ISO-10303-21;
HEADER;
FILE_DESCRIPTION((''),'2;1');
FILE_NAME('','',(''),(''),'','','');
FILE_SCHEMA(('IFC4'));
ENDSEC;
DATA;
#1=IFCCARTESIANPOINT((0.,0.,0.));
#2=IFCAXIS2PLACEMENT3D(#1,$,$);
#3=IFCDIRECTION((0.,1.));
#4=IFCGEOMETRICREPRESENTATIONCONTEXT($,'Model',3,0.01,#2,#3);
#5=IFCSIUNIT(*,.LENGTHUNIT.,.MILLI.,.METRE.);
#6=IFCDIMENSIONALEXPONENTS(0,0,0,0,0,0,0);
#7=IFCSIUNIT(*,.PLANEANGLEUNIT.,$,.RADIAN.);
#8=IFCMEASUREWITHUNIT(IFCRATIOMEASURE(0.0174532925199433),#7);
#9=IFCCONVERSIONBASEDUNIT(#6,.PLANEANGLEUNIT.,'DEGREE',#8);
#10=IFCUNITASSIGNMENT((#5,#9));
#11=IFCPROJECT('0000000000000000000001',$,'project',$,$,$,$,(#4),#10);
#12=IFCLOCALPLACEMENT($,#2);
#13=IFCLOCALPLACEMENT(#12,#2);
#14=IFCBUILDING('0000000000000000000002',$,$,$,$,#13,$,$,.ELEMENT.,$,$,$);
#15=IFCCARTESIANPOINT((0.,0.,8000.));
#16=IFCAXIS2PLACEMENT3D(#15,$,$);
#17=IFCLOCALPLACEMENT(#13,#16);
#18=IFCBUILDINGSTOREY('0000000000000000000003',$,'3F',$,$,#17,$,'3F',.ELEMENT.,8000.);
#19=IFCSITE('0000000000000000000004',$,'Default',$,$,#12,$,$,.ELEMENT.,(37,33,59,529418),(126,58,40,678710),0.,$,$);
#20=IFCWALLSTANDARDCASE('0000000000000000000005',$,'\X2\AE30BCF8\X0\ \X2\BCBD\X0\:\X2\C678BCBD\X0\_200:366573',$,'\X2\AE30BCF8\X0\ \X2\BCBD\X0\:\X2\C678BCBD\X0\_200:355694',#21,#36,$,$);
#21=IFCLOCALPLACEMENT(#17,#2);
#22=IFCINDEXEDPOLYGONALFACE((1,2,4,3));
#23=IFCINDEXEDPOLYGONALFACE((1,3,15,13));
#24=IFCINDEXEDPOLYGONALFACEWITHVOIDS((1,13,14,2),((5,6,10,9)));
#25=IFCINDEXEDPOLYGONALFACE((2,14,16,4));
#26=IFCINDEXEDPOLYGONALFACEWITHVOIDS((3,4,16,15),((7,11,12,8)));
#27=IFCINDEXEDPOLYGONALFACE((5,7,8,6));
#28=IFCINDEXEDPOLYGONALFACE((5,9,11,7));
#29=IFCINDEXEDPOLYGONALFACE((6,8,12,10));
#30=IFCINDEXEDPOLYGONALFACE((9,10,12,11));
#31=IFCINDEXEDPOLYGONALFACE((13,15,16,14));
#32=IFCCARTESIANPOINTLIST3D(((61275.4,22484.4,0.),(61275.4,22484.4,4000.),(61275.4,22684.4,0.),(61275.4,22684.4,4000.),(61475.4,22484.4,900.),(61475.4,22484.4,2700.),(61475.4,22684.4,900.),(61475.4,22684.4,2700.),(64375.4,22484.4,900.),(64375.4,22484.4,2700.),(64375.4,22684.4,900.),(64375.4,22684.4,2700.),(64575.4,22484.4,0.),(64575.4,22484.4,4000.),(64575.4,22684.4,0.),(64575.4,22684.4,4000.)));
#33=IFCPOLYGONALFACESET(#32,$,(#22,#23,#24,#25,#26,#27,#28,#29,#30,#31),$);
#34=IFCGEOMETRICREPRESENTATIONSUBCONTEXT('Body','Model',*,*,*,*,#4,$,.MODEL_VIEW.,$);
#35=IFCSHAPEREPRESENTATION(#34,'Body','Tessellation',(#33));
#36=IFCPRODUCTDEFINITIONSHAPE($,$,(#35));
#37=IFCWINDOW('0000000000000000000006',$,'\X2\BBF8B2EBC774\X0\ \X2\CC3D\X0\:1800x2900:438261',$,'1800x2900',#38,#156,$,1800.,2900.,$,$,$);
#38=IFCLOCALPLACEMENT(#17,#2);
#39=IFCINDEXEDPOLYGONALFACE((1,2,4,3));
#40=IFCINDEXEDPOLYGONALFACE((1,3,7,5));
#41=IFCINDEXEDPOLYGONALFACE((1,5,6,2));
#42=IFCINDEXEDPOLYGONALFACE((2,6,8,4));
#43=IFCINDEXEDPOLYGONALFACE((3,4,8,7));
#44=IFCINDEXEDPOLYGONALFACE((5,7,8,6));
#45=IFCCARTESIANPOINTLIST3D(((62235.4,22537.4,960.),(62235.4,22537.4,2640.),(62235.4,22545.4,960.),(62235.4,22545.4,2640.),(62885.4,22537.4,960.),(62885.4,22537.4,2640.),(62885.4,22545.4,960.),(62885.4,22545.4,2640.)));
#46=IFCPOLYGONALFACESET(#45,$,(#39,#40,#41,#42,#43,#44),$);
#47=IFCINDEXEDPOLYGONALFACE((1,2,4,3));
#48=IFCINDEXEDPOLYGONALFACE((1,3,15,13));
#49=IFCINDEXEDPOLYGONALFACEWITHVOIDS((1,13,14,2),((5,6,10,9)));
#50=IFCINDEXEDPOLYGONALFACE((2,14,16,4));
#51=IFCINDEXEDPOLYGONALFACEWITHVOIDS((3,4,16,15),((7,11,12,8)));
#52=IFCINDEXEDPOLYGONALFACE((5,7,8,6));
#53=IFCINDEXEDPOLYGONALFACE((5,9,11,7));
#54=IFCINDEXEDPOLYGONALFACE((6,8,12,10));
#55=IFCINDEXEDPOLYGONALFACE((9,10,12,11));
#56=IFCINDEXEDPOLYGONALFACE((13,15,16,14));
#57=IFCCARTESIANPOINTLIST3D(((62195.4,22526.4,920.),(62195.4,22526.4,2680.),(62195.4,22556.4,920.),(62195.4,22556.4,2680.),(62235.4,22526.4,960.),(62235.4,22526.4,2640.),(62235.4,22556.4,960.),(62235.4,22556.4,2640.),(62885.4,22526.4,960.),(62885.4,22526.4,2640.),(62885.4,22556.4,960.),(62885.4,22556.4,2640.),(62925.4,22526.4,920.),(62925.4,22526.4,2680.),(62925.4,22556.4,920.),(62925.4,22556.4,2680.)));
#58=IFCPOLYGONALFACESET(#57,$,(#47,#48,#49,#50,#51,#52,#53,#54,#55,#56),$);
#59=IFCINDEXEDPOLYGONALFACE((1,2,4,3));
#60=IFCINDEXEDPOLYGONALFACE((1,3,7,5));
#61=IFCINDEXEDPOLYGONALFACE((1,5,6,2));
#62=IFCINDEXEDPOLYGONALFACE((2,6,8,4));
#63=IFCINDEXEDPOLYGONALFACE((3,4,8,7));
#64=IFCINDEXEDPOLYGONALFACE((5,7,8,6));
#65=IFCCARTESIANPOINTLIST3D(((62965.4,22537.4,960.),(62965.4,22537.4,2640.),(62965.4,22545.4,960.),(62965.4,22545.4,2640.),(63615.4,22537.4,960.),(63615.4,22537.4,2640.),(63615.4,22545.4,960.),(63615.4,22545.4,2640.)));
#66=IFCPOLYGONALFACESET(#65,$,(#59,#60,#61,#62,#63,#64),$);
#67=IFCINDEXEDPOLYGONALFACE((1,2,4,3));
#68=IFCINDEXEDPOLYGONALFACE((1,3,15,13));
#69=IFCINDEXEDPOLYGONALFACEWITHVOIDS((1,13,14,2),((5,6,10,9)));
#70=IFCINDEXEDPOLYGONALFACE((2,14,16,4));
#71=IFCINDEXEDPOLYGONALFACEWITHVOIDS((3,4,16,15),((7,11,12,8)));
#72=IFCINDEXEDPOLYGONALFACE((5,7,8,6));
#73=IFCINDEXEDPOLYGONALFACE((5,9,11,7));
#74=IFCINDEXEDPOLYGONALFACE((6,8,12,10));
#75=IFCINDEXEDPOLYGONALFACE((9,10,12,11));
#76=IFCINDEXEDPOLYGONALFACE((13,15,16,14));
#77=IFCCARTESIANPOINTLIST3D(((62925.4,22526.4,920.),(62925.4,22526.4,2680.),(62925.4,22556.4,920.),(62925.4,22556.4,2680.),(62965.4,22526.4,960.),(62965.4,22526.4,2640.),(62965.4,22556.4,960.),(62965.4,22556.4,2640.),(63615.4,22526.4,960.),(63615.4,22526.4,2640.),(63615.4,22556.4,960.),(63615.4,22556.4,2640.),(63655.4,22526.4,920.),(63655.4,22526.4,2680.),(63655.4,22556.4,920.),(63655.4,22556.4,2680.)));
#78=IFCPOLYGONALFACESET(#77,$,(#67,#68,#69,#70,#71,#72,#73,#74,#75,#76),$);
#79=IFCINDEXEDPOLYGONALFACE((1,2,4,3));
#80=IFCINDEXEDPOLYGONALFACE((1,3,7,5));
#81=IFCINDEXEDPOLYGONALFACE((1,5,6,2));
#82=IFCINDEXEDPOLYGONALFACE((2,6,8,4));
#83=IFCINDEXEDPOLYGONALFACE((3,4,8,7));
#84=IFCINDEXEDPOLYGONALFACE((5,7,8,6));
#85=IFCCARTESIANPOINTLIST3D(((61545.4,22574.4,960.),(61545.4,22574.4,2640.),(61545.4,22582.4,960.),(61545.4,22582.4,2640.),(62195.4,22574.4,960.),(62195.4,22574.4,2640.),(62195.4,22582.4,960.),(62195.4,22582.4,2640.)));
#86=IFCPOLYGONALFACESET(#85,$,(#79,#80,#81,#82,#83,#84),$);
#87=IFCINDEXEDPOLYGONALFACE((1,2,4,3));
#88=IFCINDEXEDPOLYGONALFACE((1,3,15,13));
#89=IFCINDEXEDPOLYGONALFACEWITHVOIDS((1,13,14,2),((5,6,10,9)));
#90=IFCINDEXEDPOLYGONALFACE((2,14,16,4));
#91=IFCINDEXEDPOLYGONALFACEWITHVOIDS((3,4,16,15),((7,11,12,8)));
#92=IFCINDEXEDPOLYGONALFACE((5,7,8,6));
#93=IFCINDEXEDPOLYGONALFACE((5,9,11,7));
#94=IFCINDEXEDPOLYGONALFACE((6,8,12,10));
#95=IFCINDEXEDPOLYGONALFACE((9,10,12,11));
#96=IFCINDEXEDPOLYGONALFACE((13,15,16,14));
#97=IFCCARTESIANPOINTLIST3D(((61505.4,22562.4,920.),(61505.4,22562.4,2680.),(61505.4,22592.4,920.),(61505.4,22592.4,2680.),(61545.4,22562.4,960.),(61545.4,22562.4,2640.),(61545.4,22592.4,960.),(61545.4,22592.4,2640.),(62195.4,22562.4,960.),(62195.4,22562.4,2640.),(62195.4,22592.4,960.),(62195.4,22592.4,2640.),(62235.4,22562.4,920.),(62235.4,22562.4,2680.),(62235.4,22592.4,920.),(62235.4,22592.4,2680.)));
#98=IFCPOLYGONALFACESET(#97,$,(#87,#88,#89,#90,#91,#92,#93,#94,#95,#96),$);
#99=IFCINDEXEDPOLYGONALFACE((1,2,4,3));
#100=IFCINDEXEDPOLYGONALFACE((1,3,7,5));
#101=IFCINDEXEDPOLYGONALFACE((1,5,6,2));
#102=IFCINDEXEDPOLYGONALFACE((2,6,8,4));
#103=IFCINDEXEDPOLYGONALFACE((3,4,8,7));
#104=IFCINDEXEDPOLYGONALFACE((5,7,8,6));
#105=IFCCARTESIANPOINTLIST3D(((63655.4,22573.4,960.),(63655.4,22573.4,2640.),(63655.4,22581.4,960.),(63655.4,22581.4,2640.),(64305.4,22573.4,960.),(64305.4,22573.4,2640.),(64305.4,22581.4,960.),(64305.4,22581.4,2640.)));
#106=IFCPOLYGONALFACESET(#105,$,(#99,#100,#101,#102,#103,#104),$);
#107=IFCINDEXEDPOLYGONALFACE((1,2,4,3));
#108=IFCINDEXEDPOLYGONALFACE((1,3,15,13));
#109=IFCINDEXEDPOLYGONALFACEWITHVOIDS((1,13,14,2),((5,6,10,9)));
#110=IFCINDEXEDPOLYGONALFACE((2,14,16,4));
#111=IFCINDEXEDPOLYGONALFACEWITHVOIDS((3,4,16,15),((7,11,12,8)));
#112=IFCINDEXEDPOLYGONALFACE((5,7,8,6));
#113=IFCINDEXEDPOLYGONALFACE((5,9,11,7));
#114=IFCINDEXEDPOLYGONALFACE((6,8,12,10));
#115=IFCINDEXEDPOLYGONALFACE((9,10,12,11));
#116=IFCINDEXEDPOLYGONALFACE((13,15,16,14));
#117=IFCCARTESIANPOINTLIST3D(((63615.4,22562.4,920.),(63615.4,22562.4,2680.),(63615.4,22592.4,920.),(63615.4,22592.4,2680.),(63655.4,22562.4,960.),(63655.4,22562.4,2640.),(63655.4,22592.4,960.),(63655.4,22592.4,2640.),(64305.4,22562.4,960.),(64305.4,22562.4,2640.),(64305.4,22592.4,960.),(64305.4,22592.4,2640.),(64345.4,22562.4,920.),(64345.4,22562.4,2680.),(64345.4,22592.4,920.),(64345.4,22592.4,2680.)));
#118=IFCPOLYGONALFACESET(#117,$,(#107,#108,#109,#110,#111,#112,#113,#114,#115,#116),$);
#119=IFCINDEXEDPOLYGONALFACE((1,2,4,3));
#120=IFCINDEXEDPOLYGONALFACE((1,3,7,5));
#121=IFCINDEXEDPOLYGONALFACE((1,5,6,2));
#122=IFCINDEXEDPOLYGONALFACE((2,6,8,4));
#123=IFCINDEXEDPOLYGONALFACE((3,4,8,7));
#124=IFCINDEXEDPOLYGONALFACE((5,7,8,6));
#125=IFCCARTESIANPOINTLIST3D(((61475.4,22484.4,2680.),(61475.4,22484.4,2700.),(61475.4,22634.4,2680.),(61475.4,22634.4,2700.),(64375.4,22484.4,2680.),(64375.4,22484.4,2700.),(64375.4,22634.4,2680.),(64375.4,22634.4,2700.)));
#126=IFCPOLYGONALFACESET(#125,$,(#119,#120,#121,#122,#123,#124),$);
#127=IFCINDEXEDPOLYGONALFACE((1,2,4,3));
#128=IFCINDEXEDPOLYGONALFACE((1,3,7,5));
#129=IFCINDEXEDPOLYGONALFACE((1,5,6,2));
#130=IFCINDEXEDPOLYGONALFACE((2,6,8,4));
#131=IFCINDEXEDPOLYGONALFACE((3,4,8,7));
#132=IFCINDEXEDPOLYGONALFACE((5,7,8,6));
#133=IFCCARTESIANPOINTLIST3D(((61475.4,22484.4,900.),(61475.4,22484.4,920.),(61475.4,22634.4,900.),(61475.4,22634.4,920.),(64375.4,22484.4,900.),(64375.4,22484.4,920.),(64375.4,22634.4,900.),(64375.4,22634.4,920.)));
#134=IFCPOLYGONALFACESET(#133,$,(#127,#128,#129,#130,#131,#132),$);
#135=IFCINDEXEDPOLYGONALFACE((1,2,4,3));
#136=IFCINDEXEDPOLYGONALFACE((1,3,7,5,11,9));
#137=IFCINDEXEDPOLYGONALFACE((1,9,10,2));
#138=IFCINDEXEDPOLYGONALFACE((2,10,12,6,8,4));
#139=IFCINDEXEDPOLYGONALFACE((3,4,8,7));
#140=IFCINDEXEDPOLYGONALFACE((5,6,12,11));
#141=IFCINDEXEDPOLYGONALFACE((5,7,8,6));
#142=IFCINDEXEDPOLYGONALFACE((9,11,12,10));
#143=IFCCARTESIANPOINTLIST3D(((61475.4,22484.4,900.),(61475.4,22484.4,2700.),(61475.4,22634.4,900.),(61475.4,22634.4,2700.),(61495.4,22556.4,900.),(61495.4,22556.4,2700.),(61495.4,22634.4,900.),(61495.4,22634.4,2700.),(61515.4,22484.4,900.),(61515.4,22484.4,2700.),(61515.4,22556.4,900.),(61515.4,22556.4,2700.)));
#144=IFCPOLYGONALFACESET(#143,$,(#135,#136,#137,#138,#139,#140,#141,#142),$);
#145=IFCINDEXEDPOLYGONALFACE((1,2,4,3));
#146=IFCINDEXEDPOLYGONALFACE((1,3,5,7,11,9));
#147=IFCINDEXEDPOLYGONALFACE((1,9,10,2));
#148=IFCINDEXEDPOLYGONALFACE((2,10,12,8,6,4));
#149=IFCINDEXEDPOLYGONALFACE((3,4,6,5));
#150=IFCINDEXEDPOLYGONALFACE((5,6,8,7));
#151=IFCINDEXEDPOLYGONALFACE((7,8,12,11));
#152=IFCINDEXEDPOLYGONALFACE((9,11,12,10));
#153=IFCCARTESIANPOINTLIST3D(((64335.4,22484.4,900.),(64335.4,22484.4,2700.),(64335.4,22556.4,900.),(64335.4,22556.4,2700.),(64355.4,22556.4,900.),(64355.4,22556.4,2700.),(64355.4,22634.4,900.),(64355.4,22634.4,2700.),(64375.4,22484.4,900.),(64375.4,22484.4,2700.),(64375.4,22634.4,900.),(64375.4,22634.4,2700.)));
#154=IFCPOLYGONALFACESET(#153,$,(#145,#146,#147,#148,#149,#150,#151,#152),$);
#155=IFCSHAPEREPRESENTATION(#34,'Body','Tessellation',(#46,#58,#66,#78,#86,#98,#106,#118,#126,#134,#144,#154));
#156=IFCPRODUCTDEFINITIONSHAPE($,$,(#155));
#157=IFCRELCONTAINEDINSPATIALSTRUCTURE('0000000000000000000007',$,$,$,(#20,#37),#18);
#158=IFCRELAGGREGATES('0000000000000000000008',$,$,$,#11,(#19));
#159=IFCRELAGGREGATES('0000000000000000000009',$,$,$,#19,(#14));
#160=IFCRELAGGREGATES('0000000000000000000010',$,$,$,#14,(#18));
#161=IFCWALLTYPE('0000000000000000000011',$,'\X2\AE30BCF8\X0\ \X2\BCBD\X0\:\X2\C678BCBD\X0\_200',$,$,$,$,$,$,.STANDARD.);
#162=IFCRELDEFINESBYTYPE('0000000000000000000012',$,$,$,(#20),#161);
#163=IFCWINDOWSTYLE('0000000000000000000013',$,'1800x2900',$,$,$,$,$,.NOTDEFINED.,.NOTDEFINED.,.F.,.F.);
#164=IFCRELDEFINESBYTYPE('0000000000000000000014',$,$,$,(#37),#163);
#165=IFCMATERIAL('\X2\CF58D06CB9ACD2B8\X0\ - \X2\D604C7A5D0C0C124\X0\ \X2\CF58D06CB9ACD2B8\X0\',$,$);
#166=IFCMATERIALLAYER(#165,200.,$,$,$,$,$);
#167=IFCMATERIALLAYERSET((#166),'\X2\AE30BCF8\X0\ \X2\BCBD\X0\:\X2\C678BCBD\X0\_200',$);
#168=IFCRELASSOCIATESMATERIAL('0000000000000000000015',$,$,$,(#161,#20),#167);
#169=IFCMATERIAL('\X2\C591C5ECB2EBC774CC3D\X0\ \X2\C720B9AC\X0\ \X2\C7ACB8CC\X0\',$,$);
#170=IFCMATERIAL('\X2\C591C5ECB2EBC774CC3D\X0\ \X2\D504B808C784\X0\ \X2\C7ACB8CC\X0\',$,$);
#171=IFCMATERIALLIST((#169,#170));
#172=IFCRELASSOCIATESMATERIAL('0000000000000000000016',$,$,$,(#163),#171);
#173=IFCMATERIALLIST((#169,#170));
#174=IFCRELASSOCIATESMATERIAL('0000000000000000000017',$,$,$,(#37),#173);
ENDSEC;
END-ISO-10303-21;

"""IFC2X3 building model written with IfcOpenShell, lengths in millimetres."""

from ifc_helpers import new_model, entity, si_unit, converted_unit, direction, frame, frame_2d, origin, origin_2d_with_axis, place, context, subcontext, project, spatial, polyline, rectangle, outline, extrude, source, transform, mapped, material, material_list, layer, layer_set, layer_usage, type_object, type_shapes, element, fill, save


model = new_model("IFC2X3")

# Units and contexts
model_context = context("Model", 3, precision=0.01, world=origin(), true_north=direction((0.0, 1.0)))
body_context = subcontext(model_context, "Body", "Model", "MODEL_VIEW")
ifc_project = project(units=[si_unit("LENGTHUNIT", "METRE", prefix="MILLI"), converted_unit("PLANEANGLEUNIT", "DEGREE", entity("IfcRatioMeasure", 0.0174532925199433), si_unit("PLANEANGLEUNIT", "RADIAN"), dimensions=[0, 0, 0, 0, 0, 0, 0])], contexts=[model_context])

# Site, building, storey
site_placement = place(None, origin())
site = spatial("IfcSite", under=ifc_project, at=site_placement, Name="Default", CompositionType="ELEMENT", RefLatitude=(37, 33, 59, 529418), RefLongitude=(126, 58, 40, 678710), RefElevation=0.0)
building_placement = place(site_placement, origin())
building = spatial("IfcBuilding", under=site, at=building_placement, CompositionType="ELEMENT")
storey_placement = place(building_placement, frame((0.0, 0.0, 8000.0)))
storey = spatial("IfcBuildingStorey", under=building, at=storey_placement, Name="3F", LongName="3F", CompositionType="ELEMENT", Elevation=8000.0)

# Wall, opening, window
ifc_material_1 = material(Name="콘크리트 - 현장타설 콘크리트")
ifc_layer_1 = layer(ifc_material_1, 200.0)
ifc_layer_set_1 = layer_set([ifc_layer_1], Name="기본 벽:외벽_200")
wall_type_1 = type_object("IfcWallType", Name="기본 벽:외벽_200", PredefinedType="STANDARD", material=ifc_layer_set_1)
ifc_material_2 = material(Name="양여닫이창 유리 재료")
ifc_material_3 = material(Name="양여닫이창 프레임 재료")
ifc_material_list_1 = material_list([ifc_material_2, ifc_material_3])
window_style = type_object("IfcWindowStyle", Name="1800x2900", ConstructionType="NOTDEFINED", OperationType="NOTDEFINED", ParameterTakesPrecedence=False, Sizeable=False, material=ifc_material_list_1)
shared_shape_1 = source(origin(), body_context, "Body", "SweptSolid", [
    extrude(rectangle(XDim=8.0, YDim=650.0, at=frame_2d((0.0, 0.0), x_axis=(1.0, 0.0))), frame((1815.0, 143.0, 60.0), z_axis=(0.0, 0.0, 1.0), x_axis=(0.0, 1.0, 0.0)), (0.0, 0.0, 1.0), 1680.0),
    extrude(outline(polyline([(-880.0, -365.0), (880.0, -365.0), (880.0, 365.0), (-880.0, 365.0), (-880.0, -365.0)]), holes=[polyline([(840.0, -325.0), (-840.0, -325.0), (-840.0, 325.0), (840.0, 325.0), (840.0, -325.0)])]), frame((1815.0, 128.0, 900.0), z_axis=(0.0, 1.0, 0.0), x_axis=(0.0, 0.0, -1.0)), (0.0, 0.0, 1.0), 30.0),
    extrude(rectangle(XDim=8.0, YDim=650.0, at=frame_2d((0.0, 0.0), x_axis=(1.0, 0.0))), frame((1085.0, 143.0, 60.0), z_axis=(0.0, 0.0, 1.0), x_axis=(0.0, 1.0, 0.0)), (0.0, 0.0, 1.0), 1680.0),
    extrude(outline(polyline([(-880.0, -365.0), (880.0, -365.0), (880.0, 365.0), (-880.0, 365.0), (-880.0, -365.0)]), holes=[polyline([(840.0, -325.0), (-840.0, -325.0), (-840.0, 325.0), (840.0, 325.0), (840.0, -325.0)])]), frame((1085.0, 128.0, 900.0), z_axis=(0.0, 1.0, 0.0), x_axis=(0.0, 0.0, -1.0)), (0.0, 0.0, 1.0), 30.0),
    extrude(rectangle(XDim=8.0, YDim=650.0, at=frame_2d((0.0, 0.0), x_axis=(1.0, 0.0))), frame((2505.0, 106.0, 60.0), z_axis=(0.0, 0.0, 1.0), x_axis=(0.0, 1.0, 0.0)), (0.0, 0.0, 1.0), 1680.0),
    extrude(outline(polyline([(-880.0, -365.0), (880.0, -365.0), (880.0, 365.0), (-880.0, 365.0), (-880.0, -365.0)]), holes=[polyline([(840.0, -325.0), (-840.0, -325.0), (-840.0, 325.0), (840.0, 325.0), (840.0, -325.0)])]), frame((2505.0, 92.0, 900.0), z_axis=(0.0, 1.0, 0.0), x_axis=(0.0, 0.0, -1.0)), (0.0, 0.0, 1.0), 30.0),
    extrude(rectangle(XDim=8.0, YDim=650.0, at=origin_2d_with_axis()), frame((395.0, 107.0, 60.0), z_axis=(0.0, 0.0, 1.0), x_axis=(0.0, 1.0, 0.0)), (0.0, 0.0, 1.0), 1680.0),
    extrude(outline(polyline([(-880.0, -365.0), (880.0, -365.0), (880.0, 365.0), (-880.0, 365.0), (-880.0, -365.0)]), holes=[polyline([(840.0, -325.0), (-840.0, -325.0), (-840.0, 325.0), (840.0, 325.0), (840.0, -325.0)])]), frame((395.0, 92.0, 900.0), z_axis=(0.0, 1.0, 0.0), x_axis=(0.0, 0.0, -1.0)), (0.0, 0.0, 1.0), 30.0),
    extrude(rectangle(XDim=2900.0, YDim=150.0, at=origin_2d_with_axis()), frame((1450.0, 125.0, 1780.0), z_axis=(0.0, 0.0, 1.0), x_axis=(-1.0, 0.0, 0.0)), (0.0, 0.0, 1.0), 20.0),
    extrude(rectangle(XDim=2900.0, YDim=150.0, at=origin_2d_with_axis()), frame((1450.0, 125.0, 0.0), z_axis=(0.0, 0.0, 1.0), x_axis=(-1.0, 0.0, 0.0)), (0.0, 0.0, 1.0), 20.0),
    extrude(outline(polyline([(-74.0, -20.0), (-2.0, -20.0), (-2.0, 0.0), (76.0, 0.0), (76.0, 20.0), (-74.0, 20.0), (-74.0, -20.0)])), frame((2880.0, 126.0, 0.0), z_axis=(0.0, 0.0, 1.0), x_axis=(0.0, -1.0, 0.0)), (0.0, 0.0, 1.0), 1800.0),
    extrude(outline(polyline([(-20.0, -74.0), (20.0, -74.0), (20.0, 76.0), (0.0, 76.0), (0.0, -2.0), (-20.0, -2.0), (-20.0, -74.0)])), frame((20.0, 126.0, 0.0), z_axis=(0.0, 0.0, 1.0), x_axis=(-1.0, 0.0, 0.0)), (0.0, 0.0, 1.0), 1800.0),
])
type_shapes(window_style, [shared_shape_1])
ifc_layer_usage_1 = layer_usage(ifc_layer_set_1, "AXIS2", "NEGATIVE", 100.0)
wall_1_placement = place(storey_placement, frame((64575.4, 22584.4, 0.0), z_axis=(0.0, 0.0, 1.0), x_axis=(-1.0, 0.0, 0.0)))
wall_1 = element("IfcWallStandardCase", 1, at=wall_1_placement, inside=storey, type_object=wall_type_1, material=ifc_layer_usage_1, Name="기본 벽:외벽_200:366573", ObjectType="기본 벽:외벽_200:355694", context=body_context, shape_type="SweptSolid", body=[
    extrude(rectangle(XDim=3300.0, YDim=200.0, at=frame_2d((1650.0, 0.0), x_axis=(-1.0, 0.0))), origin(), (0.0, 0.0, 1.0), 4000.0),
])
opening_1_placement = place(wall_1_placement, frame((200.0, -100.0, 900.0)))
opening_1 = element("IfcOpeningElement", 2, at=opening_1_placement, cuts=wall_1, ObjectType="Opening", context=body_context, shape_type="SweptSolid", body=[
    extrude(rectangle(XDim=1800.0, YDim=2900.0, at=frame_2d((900.0, 1450.0), x_axis=(1.0, 0.0))), frame((0.0, 0.0, 0.0), z_axis=(0.0, 1.0, 0.0), x_axis=(0.0, 0.0, 1.0)), (0.0, 0.0, 1.0), 200.0),
])
ifc_material_list_2 = material_list([ifc_material_2, ifc_material_3])
window_1_placement = place(opening_1_placement, origin())
window_1 = element("IfcWindow", 3, at=window_1_placement, inside=storey, type_object=window_style, material=ifc_material_list_2, Name="미닫이 창:1800x2900:438261", ObjectType="1800x2900", OverallHeight=1800.0, OverallWidth=2900.0, context=body_context, shape_type="MappedRepresentation", body=[
    mapped(shared_shape_1, transform((0.0, 0.0, 0.0), scale=1.0)),
])
fill(opening_1, window_1)

save(model, "model.ifc")
